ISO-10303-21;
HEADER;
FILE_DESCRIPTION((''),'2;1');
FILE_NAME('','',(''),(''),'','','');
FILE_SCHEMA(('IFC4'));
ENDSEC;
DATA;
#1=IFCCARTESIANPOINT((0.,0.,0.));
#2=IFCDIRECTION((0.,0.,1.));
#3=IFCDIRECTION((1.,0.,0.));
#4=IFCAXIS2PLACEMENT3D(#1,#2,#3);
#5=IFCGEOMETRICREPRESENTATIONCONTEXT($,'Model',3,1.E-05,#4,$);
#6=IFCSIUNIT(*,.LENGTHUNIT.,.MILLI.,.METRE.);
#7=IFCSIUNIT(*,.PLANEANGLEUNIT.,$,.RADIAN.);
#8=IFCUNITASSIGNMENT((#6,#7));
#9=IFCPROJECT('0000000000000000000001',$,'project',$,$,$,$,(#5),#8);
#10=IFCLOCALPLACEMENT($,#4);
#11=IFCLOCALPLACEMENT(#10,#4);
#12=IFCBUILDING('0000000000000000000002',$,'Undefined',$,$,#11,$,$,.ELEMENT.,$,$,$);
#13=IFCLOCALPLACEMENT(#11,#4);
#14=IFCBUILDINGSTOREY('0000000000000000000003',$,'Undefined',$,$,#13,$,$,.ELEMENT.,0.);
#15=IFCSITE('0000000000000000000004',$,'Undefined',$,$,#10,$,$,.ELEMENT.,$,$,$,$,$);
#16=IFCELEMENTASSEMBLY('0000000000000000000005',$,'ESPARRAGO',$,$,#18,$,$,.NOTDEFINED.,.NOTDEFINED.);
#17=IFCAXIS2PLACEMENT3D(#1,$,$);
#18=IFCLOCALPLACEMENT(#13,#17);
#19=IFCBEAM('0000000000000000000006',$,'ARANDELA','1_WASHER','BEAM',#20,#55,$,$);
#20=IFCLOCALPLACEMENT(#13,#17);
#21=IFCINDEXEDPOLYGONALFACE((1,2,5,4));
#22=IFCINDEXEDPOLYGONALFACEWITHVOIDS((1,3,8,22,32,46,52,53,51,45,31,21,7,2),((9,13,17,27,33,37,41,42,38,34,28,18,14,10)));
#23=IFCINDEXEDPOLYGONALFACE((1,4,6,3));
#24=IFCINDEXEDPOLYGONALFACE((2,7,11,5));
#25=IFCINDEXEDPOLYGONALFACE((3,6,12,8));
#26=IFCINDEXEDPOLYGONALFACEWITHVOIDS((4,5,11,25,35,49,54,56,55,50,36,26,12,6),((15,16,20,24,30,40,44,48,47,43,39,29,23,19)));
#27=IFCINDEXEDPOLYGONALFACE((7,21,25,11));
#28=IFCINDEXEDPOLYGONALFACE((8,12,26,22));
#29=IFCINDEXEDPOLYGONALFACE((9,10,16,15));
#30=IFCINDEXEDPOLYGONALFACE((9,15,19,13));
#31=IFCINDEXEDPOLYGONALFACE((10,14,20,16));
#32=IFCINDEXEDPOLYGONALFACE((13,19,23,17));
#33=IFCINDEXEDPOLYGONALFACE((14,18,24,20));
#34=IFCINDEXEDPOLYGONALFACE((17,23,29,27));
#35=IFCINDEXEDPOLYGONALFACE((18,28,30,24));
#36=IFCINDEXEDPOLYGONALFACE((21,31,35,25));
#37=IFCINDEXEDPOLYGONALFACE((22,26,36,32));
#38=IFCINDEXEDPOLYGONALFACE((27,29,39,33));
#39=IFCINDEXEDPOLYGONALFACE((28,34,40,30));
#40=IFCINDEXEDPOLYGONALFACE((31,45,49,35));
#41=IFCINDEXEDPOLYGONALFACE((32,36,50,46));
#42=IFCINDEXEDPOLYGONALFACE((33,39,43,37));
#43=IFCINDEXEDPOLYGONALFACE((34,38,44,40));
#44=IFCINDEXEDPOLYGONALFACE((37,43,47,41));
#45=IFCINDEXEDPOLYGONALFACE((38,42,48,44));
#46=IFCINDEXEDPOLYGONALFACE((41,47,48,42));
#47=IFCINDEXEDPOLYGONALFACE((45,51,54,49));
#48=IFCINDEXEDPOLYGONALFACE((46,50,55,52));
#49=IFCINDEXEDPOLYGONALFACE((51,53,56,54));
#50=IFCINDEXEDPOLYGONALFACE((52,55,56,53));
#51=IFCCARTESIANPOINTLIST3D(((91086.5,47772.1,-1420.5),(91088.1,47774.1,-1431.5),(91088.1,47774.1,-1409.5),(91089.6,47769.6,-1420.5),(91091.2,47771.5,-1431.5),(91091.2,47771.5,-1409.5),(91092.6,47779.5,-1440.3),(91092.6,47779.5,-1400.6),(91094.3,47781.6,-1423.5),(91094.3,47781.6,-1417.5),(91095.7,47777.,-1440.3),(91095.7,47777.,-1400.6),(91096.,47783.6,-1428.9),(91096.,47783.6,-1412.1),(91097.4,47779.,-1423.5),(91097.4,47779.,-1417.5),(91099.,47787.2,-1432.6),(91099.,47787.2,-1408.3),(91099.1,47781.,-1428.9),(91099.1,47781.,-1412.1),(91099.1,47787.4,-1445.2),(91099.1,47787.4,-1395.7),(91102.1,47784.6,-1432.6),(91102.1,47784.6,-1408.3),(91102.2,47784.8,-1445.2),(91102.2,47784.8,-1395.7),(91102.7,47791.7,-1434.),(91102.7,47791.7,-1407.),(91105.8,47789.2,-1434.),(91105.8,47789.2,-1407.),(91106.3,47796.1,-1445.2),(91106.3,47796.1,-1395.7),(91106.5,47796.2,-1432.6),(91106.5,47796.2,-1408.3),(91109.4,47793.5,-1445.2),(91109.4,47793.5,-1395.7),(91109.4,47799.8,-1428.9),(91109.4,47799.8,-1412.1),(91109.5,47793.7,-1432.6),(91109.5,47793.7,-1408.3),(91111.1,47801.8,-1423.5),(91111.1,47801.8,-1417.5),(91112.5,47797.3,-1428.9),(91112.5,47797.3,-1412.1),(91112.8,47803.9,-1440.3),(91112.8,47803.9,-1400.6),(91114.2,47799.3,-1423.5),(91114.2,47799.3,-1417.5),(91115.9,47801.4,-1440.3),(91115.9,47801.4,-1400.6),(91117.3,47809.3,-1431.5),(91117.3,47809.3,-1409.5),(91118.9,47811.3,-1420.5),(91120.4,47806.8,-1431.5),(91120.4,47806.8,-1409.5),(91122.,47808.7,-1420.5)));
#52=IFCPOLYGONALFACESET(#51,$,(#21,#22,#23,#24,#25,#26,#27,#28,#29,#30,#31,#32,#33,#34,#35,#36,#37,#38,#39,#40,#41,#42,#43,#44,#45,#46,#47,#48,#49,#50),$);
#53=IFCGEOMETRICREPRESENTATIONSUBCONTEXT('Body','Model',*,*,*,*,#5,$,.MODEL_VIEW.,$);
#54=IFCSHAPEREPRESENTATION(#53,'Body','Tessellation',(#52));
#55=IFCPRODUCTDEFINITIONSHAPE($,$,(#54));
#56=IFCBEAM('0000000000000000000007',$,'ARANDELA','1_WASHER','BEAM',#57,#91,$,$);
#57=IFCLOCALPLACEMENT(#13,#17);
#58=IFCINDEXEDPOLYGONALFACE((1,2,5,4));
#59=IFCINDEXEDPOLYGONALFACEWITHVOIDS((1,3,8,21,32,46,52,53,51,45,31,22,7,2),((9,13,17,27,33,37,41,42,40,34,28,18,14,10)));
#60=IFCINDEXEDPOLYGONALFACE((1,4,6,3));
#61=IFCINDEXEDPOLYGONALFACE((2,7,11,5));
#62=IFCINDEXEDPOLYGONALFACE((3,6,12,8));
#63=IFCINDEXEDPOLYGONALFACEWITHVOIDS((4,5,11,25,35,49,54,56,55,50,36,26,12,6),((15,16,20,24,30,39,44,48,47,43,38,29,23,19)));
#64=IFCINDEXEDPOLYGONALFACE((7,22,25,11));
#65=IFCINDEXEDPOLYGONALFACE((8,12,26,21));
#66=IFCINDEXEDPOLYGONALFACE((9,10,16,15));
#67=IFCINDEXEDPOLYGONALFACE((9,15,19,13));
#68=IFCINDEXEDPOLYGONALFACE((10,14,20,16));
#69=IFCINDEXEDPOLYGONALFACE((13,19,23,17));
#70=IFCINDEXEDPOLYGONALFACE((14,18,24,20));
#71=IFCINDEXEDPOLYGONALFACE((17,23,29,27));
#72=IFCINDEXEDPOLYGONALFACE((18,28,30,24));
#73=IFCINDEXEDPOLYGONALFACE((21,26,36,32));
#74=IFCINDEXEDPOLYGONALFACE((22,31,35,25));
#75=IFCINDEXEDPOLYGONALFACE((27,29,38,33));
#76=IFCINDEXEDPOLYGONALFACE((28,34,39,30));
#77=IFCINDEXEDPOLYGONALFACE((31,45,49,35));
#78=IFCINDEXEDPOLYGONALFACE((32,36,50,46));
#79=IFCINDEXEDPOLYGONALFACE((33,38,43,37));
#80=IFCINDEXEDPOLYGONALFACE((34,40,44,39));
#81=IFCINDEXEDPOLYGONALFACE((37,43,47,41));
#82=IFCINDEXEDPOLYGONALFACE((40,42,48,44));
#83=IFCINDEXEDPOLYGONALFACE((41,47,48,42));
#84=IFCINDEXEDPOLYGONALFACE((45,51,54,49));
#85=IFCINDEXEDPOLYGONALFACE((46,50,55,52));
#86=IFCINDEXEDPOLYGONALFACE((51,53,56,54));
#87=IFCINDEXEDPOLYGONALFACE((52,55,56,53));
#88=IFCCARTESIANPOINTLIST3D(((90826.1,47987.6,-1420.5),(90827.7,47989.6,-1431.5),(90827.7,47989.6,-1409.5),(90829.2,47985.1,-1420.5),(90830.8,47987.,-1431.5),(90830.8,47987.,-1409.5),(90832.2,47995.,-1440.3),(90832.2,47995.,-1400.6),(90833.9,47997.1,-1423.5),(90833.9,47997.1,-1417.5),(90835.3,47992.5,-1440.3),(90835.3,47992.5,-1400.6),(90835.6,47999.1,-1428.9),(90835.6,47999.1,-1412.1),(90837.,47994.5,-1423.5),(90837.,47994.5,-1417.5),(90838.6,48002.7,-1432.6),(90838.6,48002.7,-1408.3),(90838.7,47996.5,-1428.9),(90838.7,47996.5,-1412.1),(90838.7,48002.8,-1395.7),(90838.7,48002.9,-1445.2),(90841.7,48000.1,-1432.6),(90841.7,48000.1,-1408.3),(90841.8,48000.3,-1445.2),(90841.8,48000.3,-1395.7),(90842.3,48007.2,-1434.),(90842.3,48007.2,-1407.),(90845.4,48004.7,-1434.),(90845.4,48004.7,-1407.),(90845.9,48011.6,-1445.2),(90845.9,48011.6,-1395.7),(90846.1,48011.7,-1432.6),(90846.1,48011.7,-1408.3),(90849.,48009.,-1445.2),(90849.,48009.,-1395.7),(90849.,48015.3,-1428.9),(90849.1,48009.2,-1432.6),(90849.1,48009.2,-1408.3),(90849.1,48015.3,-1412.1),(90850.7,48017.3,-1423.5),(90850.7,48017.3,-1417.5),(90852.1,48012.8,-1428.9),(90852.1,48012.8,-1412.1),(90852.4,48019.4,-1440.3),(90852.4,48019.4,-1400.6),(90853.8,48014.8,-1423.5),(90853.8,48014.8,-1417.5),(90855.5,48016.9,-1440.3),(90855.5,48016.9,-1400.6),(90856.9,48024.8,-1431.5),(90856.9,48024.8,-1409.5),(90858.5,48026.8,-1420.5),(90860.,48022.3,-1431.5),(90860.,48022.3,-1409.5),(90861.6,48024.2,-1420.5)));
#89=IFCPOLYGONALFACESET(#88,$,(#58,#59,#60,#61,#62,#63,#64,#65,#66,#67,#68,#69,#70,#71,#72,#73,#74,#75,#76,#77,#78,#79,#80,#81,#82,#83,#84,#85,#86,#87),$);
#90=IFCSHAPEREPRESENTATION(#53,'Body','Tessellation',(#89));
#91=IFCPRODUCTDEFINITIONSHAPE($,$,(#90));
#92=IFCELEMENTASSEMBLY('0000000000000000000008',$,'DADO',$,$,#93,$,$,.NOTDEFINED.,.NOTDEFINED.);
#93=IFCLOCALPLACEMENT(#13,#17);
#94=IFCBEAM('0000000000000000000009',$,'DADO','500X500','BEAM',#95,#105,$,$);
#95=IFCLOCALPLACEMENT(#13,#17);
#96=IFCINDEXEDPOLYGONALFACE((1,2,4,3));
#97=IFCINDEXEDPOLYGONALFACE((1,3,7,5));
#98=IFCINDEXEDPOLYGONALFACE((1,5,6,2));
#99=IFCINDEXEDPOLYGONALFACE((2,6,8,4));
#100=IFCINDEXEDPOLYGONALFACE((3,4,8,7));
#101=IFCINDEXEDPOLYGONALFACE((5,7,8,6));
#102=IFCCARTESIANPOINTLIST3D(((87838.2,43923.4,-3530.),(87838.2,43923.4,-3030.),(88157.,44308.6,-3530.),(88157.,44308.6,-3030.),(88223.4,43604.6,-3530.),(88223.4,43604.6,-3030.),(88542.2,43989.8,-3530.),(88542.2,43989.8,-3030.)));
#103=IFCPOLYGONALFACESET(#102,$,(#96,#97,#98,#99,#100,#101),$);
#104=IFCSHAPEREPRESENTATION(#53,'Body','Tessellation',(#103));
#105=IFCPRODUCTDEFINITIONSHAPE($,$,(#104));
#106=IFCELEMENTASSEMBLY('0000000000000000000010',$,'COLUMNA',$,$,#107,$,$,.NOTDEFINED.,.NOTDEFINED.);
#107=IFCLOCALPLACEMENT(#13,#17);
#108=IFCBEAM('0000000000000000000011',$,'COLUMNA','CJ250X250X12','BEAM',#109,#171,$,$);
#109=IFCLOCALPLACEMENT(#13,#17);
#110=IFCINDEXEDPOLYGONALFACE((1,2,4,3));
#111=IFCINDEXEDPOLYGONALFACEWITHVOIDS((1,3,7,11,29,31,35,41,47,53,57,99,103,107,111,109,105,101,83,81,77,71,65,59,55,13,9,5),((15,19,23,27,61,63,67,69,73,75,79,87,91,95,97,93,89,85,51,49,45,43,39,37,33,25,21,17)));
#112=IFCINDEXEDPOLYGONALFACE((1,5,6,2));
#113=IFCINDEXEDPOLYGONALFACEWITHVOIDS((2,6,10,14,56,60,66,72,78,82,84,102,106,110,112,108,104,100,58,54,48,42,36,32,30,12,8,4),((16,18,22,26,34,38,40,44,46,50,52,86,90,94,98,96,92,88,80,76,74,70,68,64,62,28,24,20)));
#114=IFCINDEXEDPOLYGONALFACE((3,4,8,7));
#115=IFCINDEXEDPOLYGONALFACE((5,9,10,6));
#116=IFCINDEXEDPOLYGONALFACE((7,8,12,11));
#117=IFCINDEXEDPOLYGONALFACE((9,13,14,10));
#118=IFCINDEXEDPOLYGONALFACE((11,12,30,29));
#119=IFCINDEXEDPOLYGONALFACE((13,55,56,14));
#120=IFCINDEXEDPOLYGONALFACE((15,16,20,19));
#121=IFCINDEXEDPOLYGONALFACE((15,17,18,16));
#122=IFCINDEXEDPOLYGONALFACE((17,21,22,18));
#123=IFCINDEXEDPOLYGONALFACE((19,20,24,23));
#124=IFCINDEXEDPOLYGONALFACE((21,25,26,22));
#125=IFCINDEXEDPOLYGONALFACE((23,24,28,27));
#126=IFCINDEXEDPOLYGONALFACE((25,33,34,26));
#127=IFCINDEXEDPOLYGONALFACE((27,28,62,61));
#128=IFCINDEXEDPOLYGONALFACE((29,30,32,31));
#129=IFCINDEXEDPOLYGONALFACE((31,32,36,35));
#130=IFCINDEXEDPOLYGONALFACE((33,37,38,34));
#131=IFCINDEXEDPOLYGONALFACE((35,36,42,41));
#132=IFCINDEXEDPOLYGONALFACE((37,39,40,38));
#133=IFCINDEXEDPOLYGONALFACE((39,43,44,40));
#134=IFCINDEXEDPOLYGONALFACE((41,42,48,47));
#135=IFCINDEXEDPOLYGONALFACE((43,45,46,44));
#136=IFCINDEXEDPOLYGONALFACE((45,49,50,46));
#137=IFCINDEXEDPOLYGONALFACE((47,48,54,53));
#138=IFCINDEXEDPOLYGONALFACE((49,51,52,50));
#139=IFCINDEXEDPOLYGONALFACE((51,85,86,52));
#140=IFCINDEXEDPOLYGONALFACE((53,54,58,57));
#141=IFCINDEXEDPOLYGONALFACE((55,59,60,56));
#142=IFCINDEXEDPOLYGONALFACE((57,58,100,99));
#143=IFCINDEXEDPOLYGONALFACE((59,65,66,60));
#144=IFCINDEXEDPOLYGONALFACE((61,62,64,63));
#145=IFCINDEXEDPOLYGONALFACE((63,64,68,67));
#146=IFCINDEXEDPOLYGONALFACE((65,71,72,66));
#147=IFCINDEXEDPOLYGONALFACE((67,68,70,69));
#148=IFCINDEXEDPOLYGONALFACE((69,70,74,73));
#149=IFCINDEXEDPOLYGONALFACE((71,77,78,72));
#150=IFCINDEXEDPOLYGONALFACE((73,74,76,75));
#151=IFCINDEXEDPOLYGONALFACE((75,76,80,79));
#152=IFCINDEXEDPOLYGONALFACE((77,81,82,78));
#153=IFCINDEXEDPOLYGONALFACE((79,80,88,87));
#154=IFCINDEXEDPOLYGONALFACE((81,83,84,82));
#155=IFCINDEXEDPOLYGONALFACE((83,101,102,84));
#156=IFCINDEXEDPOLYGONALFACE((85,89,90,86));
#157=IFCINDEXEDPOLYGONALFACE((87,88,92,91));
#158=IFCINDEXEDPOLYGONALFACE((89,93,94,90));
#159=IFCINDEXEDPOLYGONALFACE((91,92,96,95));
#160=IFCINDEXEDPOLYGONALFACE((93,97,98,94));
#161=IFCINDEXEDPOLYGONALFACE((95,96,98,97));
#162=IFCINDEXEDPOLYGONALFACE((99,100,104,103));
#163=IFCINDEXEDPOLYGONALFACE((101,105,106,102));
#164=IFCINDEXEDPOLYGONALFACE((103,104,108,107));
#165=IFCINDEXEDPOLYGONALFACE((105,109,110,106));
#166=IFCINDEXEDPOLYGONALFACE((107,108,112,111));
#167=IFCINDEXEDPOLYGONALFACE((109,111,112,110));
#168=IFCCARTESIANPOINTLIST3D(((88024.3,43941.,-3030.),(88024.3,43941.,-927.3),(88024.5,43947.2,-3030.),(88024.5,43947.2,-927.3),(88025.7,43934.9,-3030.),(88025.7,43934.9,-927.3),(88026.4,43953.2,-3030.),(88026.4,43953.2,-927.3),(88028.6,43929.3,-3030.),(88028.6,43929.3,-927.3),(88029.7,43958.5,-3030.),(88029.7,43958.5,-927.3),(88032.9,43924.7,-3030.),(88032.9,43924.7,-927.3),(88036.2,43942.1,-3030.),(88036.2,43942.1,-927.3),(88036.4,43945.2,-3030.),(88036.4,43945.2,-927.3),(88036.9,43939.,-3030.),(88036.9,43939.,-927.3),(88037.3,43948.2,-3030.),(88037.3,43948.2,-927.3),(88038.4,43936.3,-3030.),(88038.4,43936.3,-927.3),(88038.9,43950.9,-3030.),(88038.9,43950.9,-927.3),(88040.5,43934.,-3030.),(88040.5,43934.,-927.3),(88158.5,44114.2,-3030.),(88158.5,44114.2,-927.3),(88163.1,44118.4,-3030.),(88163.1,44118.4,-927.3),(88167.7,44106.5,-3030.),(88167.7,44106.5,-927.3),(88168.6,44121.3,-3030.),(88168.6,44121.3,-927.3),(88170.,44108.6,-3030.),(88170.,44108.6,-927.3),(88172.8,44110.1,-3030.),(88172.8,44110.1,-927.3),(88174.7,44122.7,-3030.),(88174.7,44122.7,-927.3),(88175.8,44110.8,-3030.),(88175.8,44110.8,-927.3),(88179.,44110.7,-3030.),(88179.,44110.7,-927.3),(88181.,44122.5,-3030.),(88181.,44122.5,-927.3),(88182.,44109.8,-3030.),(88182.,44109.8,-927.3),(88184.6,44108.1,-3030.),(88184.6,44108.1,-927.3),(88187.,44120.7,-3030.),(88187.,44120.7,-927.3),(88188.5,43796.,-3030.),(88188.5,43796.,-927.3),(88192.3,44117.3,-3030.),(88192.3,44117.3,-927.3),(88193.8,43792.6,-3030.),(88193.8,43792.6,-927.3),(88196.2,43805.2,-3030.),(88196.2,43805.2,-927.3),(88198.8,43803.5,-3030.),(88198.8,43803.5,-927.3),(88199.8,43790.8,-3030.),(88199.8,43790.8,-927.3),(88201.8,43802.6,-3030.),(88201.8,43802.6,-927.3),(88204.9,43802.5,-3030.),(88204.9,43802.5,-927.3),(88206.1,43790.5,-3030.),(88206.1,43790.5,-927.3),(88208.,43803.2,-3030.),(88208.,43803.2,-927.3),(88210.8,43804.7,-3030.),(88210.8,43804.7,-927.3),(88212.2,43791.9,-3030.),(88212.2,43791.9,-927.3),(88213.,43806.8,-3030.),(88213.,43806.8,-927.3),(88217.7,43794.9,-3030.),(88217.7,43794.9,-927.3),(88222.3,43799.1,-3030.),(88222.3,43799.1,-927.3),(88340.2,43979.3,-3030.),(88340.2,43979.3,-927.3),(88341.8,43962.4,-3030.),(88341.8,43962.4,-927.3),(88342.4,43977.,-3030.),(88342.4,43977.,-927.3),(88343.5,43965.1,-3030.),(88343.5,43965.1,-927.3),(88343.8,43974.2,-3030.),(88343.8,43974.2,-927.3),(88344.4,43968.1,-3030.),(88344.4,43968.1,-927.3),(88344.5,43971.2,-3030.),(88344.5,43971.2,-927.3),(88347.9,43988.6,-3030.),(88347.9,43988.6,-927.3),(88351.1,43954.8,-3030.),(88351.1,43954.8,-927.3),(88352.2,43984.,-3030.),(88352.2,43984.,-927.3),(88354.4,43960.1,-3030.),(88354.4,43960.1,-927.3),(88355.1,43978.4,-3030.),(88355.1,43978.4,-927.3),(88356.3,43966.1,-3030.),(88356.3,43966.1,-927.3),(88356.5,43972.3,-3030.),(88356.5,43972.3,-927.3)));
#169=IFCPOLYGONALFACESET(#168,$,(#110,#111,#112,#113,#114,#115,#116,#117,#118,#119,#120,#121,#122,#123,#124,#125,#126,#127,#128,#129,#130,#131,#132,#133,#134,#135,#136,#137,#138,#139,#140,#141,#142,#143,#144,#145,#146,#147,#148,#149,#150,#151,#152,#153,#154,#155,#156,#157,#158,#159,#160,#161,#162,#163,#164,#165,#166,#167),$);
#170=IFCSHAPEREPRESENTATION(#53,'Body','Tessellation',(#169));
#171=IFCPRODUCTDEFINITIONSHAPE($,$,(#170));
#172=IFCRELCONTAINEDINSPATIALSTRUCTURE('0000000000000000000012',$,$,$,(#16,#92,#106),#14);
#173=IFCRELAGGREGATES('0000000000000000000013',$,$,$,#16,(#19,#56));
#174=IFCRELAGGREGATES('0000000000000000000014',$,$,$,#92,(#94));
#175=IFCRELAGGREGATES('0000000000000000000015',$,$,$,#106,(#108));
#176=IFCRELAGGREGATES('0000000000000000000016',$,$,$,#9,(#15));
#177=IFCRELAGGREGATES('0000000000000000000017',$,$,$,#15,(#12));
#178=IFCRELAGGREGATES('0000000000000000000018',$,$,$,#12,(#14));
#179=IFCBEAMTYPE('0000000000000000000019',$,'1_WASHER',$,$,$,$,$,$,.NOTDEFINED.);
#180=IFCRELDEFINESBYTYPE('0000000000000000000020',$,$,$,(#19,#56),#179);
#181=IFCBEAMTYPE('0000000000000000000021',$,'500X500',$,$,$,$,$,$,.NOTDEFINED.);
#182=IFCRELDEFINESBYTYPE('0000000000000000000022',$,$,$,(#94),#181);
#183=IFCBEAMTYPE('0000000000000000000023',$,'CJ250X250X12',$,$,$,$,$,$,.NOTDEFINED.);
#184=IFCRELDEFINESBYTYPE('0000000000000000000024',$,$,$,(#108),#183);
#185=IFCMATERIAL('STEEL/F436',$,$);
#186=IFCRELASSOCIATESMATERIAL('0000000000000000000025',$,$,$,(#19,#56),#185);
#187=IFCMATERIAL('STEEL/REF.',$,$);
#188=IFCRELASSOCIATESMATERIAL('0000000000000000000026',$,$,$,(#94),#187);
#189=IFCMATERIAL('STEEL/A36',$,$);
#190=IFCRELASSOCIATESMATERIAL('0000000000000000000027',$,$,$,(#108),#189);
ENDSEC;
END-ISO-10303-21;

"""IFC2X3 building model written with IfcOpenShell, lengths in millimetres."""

from ifc_helpers import new_model, si_unit, frame, origin_with_axes, origin_2d_with_axis, place, context, subcontext, project, spatial, polyline, rectangle, hollow_rectangle, outline, extrude, material, type_object, element, aggregate, save


model = new_model("IFC2X3")

# Units and contexts
model_context = context("Model", 3, precision=1e-05, world=origin_with_axes())
body_context = subcontext(model_context, "Body", "Model", "MODEL_VIEW")
ifc_project = project(units=[si_unit("LENGTHUNIT", "METRE", prefix="MILLI"), si_unit("PLANEANGLEUNIT", "RADIAN")], contexts=[model_context])

# Site, building, storey
site_placement = place(None, origin_with_axes())
site = spatial("IfcSite", under=ifc_project, at=site_placement, Name="Undefined", CompositionType="ELEMENT")
building_placement = place(site_placement, origin_with_axes())
building = spatial("IfcBuilding", under=site, at=building_placement, Name="Undefined", CompositionType="ELEMENT")
storey_placement = place(building_placement, origin_with_axes())
storey = spatial("IfcBuildingStorey", under=building, at=storey_placement, Name="Undefined", CompositionType="ELEMENT", Elevation=0.0)

# Shared definitions
ifc_material_1 = material(Name="STEEL/REF.")

# Element assembly, beams
ifc_material_2 = material(Name="STEEL/F436")
beam_type_1 = type_object("IfcBeamType", Name="1_WASHER", PredefinedType="NOTDEFINED")
assembly_1_placement = place(storey_placement, origin_with_axes())
assembly_1 = element("IfcElementAssembly", 1, at=assembly_1_placement, inside=storey, Name="ESPARRAGO", AssemblyPlace="NOTDEFINED", PredefinedType="NOTDEFINED")
beam_1_placement = place(assembly_1_placement, frame((91102.7, 47791.7, -1420.5), z_axis=(0.000066, -0.000055, 1.0), x_axis=(0.770401, -0.63756, -0.000086)))
beam_1 = element("IfcBeam", 2, at=beam_1_placement, type_object=beam_type_1, material=ifc_material_2, Name="ARANDELA", Description="1_WASHER", ObjectType="BEAM", context=body_context, shape_type="SweptSolid", body=[
    extrude(outline(polyline([(-15.8, -19.9), (-22.9, -11.0), (-25.4, 0.0), (-22.9, 11.0), (-15.8, 19.9), (-5.7, 24.8), (5.7, 24.8), (15.8, 19.9), (22.9, 11.0), (25.4, 0.0), (22.9, -11.0), (15.8, -19.9), (5.7, -24.8), (-5.7, -24.8), (-15.8, -19.9)]), holes=[polyline([(-5.9, 12.2), (-10.5, 8.4), (-13.2, 3.0), (-13.2, -3.0), (-10.5, -8.4), (-5.9, -12.2), (0.0, -13.5), (5.9, -12.2), (10.5, -8.4), (13.2, -3.0), (13.2, 3.0), (10.5, 8.4), (5.9, 12.2), (0.0, 13.5), (-5.9, 12.2)])]), frame((4.0, 0.0, 0.0), z_axis=(-1.0, 0.0, 0.0), x_axis=(0.0, -1.0, 0.0)), (0.0, 0.0, 1.0), 4.0),
])
beam_2_placement = place(assembly_1_placement, frame((90842.3, 48007.2, -1420.5), z_axis=(0.000066, -0.000055, 1.0), x_axis=(0.770401, -0.63756, -0.000086)))
beam_2 = element("IfcBeam", 3, at=beam_2_placement, type_object=beam_type_1, material=ifc_material_2, Name="ARANDELA", Description="1_WASHER", ObjectType="BEAM", context=body_context, shape_type="SweptSolid", body=[
    extrude(outline(polyline([(-15.8, -19.9), (-22.9, -11.0), (-25.4, 0.0), (-22.9, 11.0), (-15.8, 19.9), (-5.7, 24.8), (5.7, 24.8), (15.8, 19.9), (22.9, 11.0), (25.4, 0.0), (22.9, -11.0), (15.8, -19.9), (5.7, -24.8), (-5.7, -24.8), (-15.8, -19.9)]), holes=[polyline([(-5.9, 12.2), (-10.5, 8.4), (-13.2, 3.0), (-13.2, -3.0), (-10.5, -8.4), (-5.9, -12.2), (0.0, -13.5), (5.9, -12.2), (10.5, -8.4), (13.2, -3.0), (13.2, 3.0), (10.5, 8.4), (5.9, 12.2), (0.0, 13.5), (-5.9, 12.2)])]), frame((4.0, 0.0, 0.0), z_axis=(-1.0, 0.0, 0.0), x_axis=(0.0, -1.0, 0.0)), (0.0, 0.0, 1.0), 4.0),
])
aggregate(assembly_1, [beam_1, beam_2])

# Element assemblies, beams
assembly_2_placement = place(storey_placement, origin_with_axes())
assembly_2 = element("IfcElementAssembly", 4, at=assembly_2_placement, inside=storey, Name="DADO", AssemblyPlace="NOTDEFINED", PredefinedType="NOTDEFINED")
beam_type_2 = type_object("IfcBeamType", Name="500X500", PredefinedType="NOTDEFINED")
beam_3_placement = place(assembly_2_placement, frame((88190.2, 43956.6, -3030.0), z_axis=(0.770402, -0.637558, 0.0), x_axis=(0.0, 0.0, -1.0)))
beam_3 = element("IfcBeam", 5, at=beam_3_placement, type_object=beam_type_2, material=ifc_material_1, Name="DADO", Description="500X500", ObjectType="BEAM", context=body_context, shape_type="SweptSolid", body=[
    extrude(rectangle(XDim=500.0, YDim=500.0, at=origin_2d_with_axis()), frame((500.0, 0.0, 0.0), z_axis=(-1.0, 0.0, 0.0), x_axis=(0.0, -1.0, 0.0)), (0.0, 0.0, 1.0), 500.0),
])
aggregate(assembly_2, [beam_3])
assembly_3_placement = place(storey_placement, origin_with_axes())
assembly_3 = element("IfcElementAssembly", 6, at=assembly_3_placement, inside=storey, Name="COLUMNA", AssemblyPlace="NOTDEFINED", PredefinedType="NOTDEFINED")
ifc_material_3 = material(Name="STEEL/A36")
beam_type_3 = type_object("IfcBeamType", Name="CJ250X250X12", PredefinedType="NOTDEFINED")
beam_4_placement = place(assembly_3_placement, frame((88190.4, 43956.6, -3030.0), z_axis=(0.770402, -0.637558, 0.0), x_axis=(0.0, 0.0, 1.0)))
beam_4 = element("IfcBeam", 7, at=beam_4_placement, type_object=beam_type_3, material=ifc_material_3, Name="COLUMNA", Description="CJ250X250X12", ObjectType="BEAM", context=body_context, shape_type="SweptSolid", body=[
    extrude(hollow_rectangle(XDim=250.0, YDim=250.0, WallThickness=12.0, InnerFilletRadius=12.0, OuterFilletRadius=24.0, at=origin_2d_with_axis()), frame((2102.7, 0.0, 0.0), z_axis=(-1.0, 0.0, 0.0), x_axis=(0.0, -1.0, 0.0)), (0.0, 0.0, 1.0), 2102.7),
])

aggregate(assembly_3, [beam_4])

save(model, "model.ifc")
